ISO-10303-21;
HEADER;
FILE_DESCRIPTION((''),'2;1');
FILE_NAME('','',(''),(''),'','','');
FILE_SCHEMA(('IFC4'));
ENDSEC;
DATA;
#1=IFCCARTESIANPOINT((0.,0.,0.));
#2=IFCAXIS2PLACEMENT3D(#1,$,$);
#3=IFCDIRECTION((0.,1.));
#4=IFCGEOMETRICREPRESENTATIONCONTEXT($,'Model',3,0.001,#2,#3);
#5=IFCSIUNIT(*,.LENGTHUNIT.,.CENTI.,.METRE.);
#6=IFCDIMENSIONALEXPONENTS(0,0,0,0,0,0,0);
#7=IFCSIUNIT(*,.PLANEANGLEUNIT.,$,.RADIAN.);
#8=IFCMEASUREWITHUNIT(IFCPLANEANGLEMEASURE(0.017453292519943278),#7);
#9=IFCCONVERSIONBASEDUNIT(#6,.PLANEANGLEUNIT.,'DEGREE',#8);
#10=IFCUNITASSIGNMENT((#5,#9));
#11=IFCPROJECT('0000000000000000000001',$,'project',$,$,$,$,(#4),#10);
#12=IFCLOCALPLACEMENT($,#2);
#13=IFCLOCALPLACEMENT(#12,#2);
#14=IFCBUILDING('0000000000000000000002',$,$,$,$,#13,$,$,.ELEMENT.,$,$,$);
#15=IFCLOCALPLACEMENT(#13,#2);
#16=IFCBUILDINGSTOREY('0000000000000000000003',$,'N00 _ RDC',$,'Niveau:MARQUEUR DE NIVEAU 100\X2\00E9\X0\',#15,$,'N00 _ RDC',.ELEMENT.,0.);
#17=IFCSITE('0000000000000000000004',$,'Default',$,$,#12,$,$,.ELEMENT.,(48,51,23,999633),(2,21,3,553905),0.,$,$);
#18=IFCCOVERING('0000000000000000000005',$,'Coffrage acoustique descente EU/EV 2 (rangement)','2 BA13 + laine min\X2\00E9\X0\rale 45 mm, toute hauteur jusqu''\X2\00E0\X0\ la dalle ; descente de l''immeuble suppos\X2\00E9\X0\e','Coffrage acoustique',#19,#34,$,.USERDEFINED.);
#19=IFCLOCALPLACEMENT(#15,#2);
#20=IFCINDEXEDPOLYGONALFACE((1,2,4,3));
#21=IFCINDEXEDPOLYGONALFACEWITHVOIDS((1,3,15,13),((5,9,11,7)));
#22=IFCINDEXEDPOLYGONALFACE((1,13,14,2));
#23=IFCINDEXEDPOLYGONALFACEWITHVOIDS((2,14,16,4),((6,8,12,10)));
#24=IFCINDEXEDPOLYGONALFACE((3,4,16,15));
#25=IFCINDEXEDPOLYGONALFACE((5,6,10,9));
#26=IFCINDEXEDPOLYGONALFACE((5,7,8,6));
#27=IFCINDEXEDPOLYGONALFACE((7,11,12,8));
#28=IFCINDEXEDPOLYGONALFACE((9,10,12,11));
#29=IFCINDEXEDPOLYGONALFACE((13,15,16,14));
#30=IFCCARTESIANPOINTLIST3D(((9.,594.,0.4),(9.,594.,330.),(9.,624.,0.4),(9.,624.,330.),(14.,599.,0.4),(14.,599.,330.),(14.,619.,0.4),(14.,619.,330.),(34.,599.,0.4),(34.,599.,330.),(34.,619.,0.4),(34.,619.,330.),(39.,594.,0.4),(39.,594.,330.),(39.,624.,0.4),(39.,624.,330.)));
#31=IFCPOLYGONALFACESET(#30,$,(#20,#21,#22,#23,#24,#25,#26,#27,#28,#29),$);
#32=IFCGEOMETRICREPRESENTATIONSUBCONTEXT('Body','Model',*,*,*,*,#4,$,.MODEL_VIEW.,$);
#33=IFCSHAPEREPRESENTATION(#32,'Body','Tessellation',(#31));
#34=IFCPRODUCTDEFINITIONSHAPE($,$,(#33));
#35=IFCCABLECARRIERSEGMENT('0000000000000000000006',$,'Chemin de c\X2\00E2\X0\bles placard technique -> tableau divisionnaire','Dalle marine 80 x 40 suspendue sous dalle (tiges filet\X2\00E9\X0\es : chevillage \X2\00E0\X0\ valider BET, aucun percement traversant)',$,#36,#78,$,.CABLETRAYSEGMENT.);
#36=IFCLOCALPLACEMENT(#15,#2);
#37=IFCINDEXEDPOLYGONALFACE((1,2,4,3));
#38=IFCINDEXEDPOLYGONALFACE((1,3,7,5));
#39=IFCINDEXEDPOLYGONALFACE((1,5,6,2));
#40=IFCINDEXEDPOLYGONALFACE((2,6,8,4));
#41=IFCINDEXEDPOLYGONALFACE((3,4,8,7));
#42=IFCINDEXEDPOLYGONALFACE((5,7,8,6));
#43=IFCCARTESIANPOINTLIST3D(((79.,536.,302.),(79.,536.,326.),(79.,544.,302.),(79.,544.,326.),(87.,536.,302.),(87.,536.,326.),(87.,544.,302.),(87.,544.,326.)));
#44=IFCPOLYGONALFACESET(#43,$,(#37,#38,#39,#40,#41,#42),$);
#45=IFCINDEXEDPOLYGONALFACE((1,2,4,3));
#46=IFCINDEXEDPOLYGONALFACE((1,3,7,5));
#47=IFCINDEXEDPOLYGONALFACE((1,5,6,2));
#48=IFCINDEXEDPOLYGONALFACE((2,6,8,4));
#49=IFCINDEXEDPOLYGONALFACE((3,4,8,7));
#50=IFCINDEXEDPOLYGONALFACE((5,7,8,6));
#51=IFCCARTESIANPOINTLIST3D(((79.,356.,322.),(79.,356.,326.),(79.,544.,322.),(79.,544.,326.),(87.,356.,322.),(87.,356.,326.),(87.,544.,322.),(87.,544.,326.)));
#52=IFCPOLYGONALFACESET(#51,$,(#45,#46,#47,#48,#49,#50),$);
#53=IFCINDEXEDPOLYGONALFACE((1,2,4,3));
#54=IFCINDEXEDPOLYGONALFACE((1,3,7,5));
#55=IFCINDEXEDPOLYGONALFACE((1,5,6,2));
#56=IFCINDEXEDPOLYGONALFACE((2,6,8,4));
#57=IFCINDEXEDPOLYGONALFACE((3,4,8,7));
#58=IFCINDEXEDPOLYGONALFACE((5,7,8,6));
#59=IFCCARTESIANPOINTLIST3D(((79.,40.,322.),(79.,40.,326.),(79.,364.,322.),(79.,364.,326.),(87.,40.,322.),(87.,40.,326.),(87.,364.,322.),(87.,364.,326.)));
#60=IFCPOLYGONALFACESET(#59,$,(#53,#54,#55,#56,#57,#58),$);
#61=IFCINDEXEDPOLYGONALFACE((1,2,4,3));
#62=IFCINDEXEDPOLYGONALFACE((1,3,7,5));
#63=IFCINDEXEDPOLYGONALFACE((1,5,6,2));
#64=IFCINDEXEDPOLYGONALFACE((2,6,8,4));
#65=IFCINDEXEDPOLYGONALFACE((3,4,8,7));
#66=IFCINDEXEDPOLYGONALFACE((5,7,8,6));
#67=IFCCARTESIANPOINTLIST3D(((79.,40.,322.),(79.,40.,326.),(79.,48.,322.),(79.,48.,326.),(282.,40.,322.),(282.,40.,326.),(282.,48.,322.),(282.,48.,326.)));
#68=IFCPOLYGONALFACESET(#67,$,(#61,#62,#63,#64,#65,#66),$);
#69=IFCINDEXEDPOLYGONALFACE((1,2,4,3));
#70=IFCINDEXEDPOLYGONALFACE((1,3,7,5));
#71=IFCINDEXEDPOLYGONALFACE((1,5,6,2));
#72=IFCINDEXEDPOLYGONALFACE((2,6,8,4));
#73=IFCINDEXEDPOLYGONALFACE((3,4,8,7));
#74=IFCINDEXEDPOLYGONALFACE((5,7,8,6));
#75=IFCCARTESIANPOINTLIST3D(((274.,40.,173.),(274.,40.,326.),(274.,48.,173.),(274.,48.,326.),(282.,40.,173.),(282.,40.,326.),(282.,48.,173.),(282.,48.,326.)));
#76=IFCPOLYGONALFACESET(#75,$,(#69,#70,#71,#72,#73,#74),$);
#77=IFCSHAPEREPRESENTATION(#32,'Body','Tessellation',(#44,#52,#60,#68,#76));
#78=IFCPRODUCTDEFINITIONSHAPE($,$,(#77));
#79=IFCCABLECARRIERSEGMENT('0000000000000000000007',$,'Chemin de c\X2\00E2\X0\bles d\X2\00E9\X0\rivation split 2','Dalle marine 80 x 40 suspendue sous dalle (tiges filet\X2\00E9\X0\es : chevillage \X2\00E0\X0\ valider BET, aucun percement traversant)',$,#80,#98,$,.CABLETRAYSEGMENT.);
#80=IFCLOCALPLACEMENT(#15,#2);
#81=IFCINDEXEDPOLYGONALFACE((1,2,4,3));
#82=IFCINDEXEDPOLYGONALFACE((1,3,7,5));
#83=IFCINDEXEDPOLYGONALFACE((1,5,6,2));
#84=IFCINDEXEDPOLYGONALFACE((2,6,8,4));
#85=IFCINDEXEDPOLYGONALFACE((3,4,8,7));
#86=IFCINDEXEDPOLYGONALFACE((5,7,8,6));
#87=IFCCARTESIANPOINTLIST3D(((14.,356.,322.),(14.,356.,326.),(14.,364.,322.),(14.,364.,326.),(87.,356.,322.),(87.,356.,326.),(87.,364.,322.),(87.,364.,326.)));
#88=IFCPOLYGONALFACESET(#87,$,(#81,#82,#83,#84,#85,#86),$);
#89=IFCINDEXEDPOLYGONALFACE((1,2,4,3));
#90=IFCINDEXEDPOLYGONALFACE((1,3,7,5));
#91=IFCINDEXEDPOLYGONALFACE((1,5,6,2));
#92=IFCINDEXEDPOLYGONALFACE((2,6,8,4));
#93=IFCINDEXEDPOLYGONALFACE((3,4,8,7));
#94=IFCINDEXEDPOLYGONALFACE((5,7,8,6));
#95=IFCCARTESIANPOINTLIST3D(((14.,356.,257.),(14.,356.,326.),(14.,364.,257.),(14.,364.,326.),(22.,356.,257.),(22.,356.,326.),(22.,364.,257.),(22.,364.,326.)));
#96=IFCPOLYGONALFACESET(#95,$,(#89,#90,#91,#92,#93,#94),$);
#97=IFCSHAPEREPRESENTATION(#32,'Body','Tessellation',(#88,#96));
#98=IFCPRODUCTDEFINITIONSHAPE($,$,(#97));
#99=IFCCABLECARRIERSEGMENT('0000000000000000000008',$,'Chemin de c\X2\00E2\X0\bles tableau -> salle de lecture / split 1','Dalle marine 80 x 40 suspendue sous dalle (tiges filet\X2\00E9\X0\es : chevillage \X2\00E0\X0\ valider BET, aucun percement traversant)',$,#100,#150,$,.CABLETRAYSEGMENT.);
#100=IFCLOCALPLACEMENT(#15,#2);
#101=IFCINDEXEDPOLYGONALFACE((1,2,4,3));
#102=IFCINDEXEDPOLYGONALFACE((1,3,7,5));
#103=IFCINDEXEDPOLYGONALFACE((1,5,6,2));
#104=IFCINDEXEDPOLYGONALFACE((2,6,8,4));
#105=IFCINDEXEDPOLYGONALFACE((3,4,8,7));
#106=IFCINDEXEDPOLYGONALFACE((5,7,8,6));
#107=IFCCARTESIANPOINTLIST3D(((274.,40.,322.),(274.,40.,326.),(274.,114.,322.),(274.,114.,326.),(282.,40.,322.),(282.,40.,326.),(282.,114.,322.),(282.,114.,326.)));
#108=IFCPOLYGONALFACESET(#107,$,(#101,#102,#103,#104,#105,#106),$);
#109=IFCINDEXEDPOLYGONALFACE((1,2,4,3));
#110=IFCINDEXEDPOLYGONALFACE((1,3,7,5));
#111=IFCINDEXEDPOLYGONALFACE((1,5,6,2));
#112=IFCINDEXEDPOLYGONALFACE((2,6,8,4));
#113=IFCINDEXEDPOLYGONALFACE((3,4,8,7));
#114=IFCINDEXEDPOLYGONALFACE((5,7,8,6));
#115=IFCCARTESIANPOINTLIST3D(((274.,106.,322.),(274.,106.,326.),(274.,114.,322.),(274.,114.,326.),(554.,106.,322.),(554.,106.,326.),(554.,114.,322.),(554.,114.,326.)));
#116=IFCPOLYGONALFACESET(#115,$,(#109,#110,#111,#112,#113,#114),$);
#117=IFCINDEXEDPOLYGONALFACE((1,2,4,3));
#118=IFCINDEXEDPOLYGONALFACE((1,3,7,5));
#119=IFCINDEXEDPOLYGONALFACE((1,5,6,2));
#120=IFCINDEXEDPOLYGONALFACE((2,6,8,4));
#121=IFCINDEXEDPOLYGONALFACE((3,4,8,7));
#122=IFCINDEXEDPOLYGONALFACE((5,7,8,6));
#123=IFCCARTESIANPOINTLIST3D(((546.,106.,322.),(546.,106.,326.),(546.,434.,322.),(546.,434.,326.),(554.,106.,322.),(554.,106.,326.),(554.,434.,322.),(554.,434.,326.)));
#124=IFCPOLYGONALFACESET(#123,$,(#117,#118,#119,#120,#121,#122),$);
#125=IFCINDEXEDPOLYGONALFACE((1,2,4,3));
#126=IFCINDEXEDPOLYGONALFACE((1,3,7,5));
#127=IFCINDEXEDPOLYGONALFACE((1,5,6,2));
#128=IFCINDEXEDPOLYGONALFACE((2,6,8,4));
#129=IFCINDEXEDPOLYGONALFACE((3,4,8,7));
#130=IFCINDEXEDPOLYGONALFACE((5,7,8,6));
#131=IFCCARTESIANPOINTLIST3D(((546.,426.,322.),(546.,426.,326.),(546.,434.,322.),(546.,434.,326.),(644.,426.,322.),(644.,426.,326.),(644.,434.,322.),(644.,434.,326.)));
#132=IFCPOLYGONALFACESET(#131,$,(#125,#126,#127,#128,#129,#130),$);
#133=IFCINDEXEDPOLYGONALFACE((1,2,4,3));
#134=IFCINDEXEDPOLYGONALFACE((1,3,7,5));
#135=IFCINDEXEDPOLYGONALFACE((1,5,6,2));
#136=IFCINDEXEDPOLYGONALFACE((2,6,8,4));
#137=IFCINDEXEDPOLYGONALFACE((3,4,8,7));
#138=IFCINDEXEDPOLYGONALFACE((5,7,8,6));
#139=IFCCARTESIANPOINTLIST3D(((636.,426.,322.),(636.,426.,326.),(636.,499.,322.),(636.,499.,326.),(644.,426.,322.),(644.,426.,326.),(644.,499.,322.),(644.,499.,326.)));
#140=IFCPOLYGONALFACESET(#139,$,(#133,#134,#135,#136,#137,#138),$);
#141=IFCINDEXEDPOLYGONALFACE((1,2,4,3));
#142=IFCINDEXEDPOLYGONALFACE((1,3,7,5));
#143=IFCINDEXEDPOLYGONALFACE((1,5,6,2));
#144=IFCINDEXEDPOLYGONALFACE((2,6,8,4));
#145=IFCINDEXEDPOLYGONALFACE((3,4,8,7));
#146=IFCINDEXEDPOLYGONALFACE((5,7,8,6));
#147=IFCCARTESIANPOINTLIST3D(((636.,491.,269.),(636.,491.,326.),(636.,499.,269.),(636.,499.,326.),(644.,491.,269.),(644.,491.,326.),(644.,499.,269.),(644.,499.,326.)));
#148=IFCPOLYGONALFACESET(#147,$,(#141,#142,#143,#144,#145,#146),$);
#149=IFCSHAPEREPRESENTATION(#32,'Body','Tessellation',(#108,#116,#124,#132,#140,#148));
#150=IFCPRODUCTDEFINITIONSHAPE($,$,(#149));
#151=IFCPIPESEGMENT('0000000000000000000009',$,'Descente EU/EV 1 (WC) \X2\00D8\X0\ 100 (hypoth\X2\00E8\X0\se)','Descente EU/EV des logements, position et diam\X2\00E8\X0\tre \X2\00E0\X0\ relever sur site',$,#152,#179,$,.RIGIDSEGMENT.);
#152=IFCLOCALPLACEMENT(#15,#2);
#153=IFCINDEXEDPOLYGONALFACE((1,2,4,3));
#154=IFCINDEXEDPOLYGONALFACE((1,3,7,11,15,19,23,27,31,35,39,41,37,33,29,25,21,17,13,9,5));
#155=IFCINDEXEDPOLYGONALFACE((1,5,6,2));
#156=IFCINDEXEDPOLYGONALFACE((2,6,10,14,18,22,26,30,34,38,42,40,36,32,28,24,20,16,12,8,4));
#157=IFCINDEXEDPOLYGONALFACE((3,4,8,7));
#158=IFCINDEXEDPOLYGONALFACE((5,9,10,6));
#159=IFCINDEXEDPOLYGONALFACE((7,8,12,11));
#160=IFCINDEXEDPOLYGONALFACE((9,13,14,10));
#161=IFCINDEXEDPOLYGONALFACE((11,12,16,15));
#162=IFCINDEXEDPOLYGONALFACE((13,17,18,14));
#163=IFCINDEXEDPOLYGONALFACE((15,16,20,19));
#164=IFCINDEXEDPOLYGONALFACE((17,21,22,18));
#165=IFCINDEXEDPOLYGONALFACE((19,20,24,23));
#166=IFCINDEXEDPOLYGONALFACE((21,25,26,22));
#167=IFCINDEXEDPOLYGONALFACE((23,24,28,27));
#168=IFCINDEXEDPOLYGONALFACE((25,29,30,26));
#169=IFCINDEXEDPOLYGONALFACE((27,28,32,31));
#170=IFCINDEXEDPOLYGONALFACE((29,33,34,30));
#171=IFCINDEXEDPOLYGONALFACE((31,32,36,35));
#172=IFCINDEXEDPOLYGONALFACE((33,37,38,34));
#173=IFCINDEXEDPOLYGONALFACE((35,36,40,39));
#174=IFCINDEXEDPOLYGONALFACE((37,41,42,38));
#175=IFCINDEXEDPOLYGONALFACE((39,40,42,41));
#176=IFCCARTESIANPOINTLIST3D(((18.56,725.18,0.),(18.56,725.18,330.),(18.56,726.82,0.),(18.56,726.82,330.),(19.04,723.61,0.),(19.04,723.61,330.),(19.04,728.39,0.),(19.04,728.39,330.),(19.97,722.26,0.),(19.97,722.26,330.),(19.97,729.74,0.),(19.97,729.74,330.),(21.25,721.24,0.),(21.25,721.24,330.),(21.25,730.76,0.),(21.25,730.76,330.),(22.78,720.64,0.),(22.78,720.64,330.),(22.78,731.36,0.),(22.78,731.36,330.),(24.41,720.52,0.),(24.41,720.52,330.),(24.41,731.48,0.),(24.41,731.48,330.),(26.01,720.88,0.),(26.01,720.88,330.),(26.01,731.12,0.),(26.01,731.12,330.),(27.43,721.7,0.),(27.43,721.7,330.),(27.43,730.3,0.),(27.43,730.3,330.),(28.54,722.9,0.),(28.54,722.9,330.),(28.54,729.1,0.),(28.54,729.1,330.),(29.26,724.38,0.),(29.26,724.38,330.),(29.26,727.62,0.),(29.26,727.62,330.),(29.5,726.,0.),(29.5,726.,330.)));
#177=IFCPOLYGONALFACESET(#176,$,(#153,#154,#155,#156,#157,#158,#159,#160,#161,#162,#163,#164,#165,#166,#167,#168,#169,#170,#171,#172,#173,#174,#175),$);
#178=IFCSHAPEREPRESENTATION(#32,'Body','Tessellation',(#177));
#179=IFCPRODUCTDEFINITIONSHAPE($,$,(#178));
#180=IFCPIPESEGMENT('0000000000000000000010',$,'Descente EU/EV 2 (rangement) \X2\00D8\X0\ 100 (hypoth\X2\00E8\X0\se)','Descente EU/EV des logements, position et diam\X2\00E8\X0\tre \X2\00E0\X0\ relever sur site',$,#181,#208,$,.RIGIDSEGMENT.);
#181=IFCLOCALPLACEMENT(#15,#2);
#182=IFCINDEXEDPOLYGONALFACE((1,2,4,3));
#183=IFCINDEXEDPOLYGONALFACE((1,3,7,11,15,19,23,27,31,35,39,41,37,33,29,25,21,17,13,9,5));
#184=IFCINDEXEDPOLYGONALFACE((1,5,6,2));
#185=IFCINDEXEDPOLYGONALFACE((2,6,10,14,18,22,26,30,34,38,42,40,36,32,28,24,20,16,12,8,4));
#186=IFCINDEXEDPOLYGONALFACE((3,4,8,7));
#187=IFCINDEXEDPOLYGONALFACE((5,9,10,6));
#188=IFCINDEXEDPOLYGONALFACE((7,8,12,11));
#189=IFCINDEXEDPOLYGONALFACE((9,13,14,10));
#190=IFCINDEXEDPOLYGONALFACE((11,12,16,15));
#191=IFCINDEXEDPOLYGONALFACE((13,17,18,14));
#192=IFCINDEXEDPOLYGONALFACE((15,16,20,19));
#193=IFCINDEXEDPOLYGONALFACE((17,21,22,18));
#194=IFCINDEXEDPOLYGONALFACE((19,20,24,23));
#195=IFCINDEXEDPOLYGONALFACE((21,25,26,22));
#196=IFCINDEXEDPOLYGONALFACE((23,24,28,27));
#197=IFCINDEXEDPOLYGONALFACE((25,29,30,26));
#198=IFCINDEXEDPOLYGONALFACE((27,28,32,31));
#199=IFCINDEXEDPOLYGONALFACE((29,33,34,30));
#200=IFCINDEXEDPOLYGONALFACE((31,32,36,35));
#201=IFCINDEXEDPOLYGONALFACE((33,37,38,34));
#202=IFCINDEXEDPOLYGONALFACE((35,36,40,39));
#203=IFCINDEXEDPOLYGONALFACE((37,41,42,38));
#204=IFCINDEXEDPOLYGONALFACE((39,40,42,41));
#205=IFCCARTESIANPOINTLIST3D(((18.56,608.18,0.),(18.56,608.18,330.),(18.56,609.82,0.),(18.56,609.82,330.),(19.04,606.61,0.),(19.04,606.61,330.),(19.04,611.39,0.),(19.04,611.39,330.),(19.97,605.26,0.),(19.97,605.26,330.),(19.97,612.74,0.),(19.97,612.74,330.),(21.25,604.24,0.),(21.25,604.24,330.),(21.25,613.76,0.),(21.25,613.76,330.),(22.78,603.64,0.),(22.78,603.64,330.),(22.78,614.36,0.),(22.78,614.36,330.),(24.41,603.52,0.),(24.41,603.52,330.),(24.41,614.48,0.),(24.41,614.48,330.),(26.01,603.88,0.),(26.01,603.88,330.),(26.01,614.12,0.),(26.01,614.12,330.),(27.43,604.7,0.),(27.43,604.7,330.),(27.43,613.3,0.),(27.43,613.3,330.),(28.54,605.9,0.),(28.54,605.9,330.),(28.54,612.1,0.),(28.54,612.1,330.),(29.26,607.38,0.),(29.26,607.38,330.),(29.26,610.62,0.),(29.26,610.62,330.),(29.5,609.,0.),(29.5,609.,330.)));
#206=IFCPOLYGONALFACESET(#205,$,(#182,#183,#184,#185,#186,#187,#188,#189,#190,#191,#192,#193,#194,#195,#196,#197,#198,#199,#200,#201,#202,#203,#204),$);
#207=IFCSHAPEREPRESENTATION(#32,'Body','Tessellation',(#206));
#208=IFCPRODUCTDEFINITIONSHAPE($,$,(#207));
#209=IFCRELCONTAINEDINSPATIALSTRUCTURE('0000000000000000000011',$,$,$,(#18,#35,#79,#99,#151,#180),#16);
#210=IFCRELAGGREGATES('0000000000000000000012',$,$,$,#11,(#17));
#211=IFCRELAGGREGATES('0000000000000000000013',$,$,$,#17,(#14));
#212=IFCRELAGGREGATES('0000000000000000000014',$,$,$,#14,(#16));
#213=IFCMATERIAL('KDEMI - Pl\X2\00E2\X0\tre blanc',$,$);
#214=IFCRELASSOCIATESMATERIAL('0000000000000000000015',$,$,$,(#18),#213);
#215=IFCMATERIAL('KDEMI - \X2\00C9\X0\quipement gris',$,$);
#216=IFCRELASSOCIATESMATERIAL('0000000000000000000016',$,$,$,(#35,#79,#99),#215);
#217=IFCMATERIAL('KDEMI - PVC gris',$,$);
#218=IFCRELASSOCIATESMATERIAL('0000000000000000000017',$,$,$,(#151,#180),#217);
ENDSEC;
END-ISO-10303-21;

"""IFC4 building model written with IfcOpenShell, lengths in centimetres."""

from ifc_helpers import new_model, entity, si_unit, converted_unit, direction, frame, frame_2d, origin, origin_with_axes, place, context, subcontext, project, spatial, rectangle, hollow_rectangle, circle, extrude, material, element, save


model = new_model("IFC4")

# Units and contexts
model_context = context("Model", 3, precision=0.001, world=origin(), true_north=direction((0.0, 1.0)))
body_context = subcontext(model_context, "Body", "Model", "MODEL_VIEW")
ifc_project = project(units=[si_unit("LENGTHUNIT", "METRE", prefix="CENTI"), converted_unit("PLANEANGLEUNIT", "DEGREE", entity("IfcPlaneAngleMeasure", 0.017453292519943278), si_unit("PLANEANGLEUNIT", "RADIAN"), dimensions=[0, 0, 0, 0, 0, 0, 0])], contexts=[model_context])

# Site, building, storey
site_placement = place(None, origin())
site = spatial("IfcSite", under=ifc_project, at=site_placement, Name="Default", CompositionType="ELEMENT", RefLatitude=(48, 51, 23, 999633), RefLongitude=(2, 21, 3, 553905), RefElevation=0.0)
building_placement = place(site_placement, origin())
building = spatial("IfcBuilding", under=site, at=building_placement, CompositionType="ELEMENT")
storey_placement = place(building_placement, origin())
storey = spatial("IfcBuildingStorey", under=building, at=storey_placement, Name="N00 _ RDC", ObjectType="Niveau:MARQUEUR DE NIVEAU 100é", LongName="N00 _ RDC", CompositionType="ELEMENT", Elevation=0.0)

# Covering
ifc_material_1 = material(Name="KDEMI - Plâtre blanc")
covering_1_placement = place(storey_placement, origin_with_axes())
element("IfcCovering", 1, at=covering_1_placement, inside=storey, material=ifc_material_1, Name="Coffrage acoustique descente EU/EV 2 (rangement)", Description="2 BA13 + laine minérale 45 mm, toute hauteur jusqu'à la dalle ; descente de l'immeuble supposée", ObjectType="Coffrage acoustique", PredefinedType="USERDEFINED", context=body_context, shape_type="SweptSolid", body=[
    extrude(hollow_rectangle(XDim=30.0, YDim=30.0, WallThickness=5.0, at=frame_2d((24.0, 609.0))), frame((0.0, 0.0, 0.4)), (0.0, 0.0, 1.0), 329.6),
])

# Cable carrier segments
ifc_material_2 = material(Name="KDEMI - Équipement gris")
cable_carrier_segment_1_placement = place(storey_placement, origin_with_axes())
element("IfcCableCarrierSegment", 2, at=cable_carrier_segment_1_placement, inside=storey, material=ifc_material_2, Name="Chemin de câbles placard technique -> tableau divisionnaire", Description="Dalle marine 80 x 40 suspendue sous dalle (tiges filetées : chevillage à valider BET, aucun percement traversant)", PredefinedType="CABLETRAYSEGMENT", context=body_context, shape_type="SweptSolid", body=[
    extrude(rectangle(XDim=8.0, YDim=8.0, at=frame_2d((83.0, 540.0))), frame((0.0, 0.0, 302.0)), (0.0, 0.0, 1.0), 24.0),
    extrude(rectangle(XDim=8.0, YDim=188.0, at=frame_2d((83.0, 450.0))), frame((0.0, 0.0, 322.0)), (0.0, 0.0, 1.0), 4.0),
    extrude(rectangle(XDim=8.0, YDim=324.0, at=frame_2d((83.0, 202.0))), frame((0.0, 0.0, 322.0)), (0.0, 0.0, 1.0), 4.0),
    extrude(rectangle(XDim=203.0, YDim=8.0, at=frame_2d((180.5, 44.0))), frame((0.0, 0.0, 322.0)), (0.0, 0.0, 1.0), 4.0),
    extrude(rectangle(XDim=8.0, YDim=8.0, at=frame_2d((278.0, 44.0))), frame((0.0, 0.0, 173.0)), (0.0, 0.0, 1.0), 153.0),
])
cable_carrier_segment_2_placement = place(storey_placement, origin_with_axes())
element("IfcCableCarrierSegment", 3, at=cable_carrier_segment_2_placement, inside=storey, material=ifc_material_2, Name="Chemin de câbles dérivation split 2", Description="Dalle marine 80 x 40 suspendue sous dalle (tiges filetées : chevillage à valider BET, aucun percement traversant)", PredefinedType="CABLETRAYSEGMENT", context=body_context, shape_type="SweptSolid", body=[
    extrude(rectangle(XDim=73.0, YDim=8.0, at=frame_2d((50.5, 360.0))), frame((0.0, 0.0, 322.0)), (0.0, 0.0, 1.0), 4.0),
    extrude(rectangle(XDim=8.0, YDim=8.0, at=frame_2d((18.0, 360.0))), frame((0.0, 0.0, 257.0)), (0.0, 0.0, 1.0), 69.0),
])
cable_carrier_segment_3_placement = place(storey_placement, origin_with_axes())
element("IfcCableCarrierSegment", 4, at=cable_carrier_segment_3_placement, inside=storey, material=ifc_material_2, Name="Chemin de câbles tableau -> salle de lecture / split 1", Description="Dalle marine 80 x 40 suspendue sous dalle (tiges filetées : chevillage à valider BET, aucun percement traversant)", PredefinedType="CABLETRAYSEGMENT", context=body_context, shape_type="SweptSolid", body=[
    extrude(rectangle(XDim=8.0, YDim=74.0, at=frame_2d((278.0, 77.0))), frame((0.0, 0.0, 322.0)), (0.0, 0.0, 1.0), 4.0),
    extrude(rectangle(XDim=280.0, YDim=8.0, at=frame_2d((414.0, 110.0))), frame((0.0, 0.0, 322.0)), (0.0, 0.0, 1.0), 4.0),
    extrude(rectangle(XDim=8.0, YDim=328.0, at=frame_2d((550.0, 270.0))), frame((0.0, 0.0, 322.0)), (0.0, 0.0, 1.0), 4.0),
    extrude(rectangle(XDim=98.0, YDim=8.0, at=frame_2d((595.0, 430.0))), frame((0.0, 0.0, 322.0)), (0.0, 0.0, 1.0), 4.0),
    extrude(rectangle(XDim=8.0, YDim=73.0, at=frame_2d((640.0, 462.5))), frame((0.0, 0.0, 322.0)), (0.0, 0.0, 1.0), 4.0),
    extrude(rectangle(XDim=8.0, YDim=8.0, at=frame_2d((640.0, 495.0))), frame((0.0, 0.0, 269.0)), (0.0, 0.0, 1.0), 57.0),
])

# Pipe segments
ifc_material_3 = material(Name="KDEMI - PVC gris")
pipe_segment_1_placement = place(storey_placement, origin_with_axes())
element("IfcPipeSegment", 5, at=pipe_segment_1_placement, inside=storey, material=ifc_material_3, Name="Descente EU/EV 1 (WC) Ø 100 (hypothèse)", Description="Descente EU/EV des logements, position et diamètre à relever sur site", PredefinedType="RIGIDSEGMENT", context=body_context, shape_type="SweptSolid", body=[
    extrude(circle(Radius=5.5, at=frame_2d((24.0, 726.0))), origin(), (0.0, 0.0, 1.0), 330.0),
])
pipe_segment_2_placement = place(storey_placement, origin_with_axes())
element("IfcPipeSegment", 6, at=pipe_segment_2_placement, inside=storey, material=ifc_material_3, Name="Descente EU/EV 2 (rangement) Ø 100 (hypothèse)", Description="Descente EU/EV des logements, position et diamètre à relever sur site", PredefinedType="RIGIDSEGMENT", context=body_context, shape_type="SweptSolid", body=[
    extrude(circle(Radius=5.5, at=frame_2d((24.0, 609.0))), origin(), (0.0, 0.0, 1.0), 330.0),
])

save(model, "model.ifc")
